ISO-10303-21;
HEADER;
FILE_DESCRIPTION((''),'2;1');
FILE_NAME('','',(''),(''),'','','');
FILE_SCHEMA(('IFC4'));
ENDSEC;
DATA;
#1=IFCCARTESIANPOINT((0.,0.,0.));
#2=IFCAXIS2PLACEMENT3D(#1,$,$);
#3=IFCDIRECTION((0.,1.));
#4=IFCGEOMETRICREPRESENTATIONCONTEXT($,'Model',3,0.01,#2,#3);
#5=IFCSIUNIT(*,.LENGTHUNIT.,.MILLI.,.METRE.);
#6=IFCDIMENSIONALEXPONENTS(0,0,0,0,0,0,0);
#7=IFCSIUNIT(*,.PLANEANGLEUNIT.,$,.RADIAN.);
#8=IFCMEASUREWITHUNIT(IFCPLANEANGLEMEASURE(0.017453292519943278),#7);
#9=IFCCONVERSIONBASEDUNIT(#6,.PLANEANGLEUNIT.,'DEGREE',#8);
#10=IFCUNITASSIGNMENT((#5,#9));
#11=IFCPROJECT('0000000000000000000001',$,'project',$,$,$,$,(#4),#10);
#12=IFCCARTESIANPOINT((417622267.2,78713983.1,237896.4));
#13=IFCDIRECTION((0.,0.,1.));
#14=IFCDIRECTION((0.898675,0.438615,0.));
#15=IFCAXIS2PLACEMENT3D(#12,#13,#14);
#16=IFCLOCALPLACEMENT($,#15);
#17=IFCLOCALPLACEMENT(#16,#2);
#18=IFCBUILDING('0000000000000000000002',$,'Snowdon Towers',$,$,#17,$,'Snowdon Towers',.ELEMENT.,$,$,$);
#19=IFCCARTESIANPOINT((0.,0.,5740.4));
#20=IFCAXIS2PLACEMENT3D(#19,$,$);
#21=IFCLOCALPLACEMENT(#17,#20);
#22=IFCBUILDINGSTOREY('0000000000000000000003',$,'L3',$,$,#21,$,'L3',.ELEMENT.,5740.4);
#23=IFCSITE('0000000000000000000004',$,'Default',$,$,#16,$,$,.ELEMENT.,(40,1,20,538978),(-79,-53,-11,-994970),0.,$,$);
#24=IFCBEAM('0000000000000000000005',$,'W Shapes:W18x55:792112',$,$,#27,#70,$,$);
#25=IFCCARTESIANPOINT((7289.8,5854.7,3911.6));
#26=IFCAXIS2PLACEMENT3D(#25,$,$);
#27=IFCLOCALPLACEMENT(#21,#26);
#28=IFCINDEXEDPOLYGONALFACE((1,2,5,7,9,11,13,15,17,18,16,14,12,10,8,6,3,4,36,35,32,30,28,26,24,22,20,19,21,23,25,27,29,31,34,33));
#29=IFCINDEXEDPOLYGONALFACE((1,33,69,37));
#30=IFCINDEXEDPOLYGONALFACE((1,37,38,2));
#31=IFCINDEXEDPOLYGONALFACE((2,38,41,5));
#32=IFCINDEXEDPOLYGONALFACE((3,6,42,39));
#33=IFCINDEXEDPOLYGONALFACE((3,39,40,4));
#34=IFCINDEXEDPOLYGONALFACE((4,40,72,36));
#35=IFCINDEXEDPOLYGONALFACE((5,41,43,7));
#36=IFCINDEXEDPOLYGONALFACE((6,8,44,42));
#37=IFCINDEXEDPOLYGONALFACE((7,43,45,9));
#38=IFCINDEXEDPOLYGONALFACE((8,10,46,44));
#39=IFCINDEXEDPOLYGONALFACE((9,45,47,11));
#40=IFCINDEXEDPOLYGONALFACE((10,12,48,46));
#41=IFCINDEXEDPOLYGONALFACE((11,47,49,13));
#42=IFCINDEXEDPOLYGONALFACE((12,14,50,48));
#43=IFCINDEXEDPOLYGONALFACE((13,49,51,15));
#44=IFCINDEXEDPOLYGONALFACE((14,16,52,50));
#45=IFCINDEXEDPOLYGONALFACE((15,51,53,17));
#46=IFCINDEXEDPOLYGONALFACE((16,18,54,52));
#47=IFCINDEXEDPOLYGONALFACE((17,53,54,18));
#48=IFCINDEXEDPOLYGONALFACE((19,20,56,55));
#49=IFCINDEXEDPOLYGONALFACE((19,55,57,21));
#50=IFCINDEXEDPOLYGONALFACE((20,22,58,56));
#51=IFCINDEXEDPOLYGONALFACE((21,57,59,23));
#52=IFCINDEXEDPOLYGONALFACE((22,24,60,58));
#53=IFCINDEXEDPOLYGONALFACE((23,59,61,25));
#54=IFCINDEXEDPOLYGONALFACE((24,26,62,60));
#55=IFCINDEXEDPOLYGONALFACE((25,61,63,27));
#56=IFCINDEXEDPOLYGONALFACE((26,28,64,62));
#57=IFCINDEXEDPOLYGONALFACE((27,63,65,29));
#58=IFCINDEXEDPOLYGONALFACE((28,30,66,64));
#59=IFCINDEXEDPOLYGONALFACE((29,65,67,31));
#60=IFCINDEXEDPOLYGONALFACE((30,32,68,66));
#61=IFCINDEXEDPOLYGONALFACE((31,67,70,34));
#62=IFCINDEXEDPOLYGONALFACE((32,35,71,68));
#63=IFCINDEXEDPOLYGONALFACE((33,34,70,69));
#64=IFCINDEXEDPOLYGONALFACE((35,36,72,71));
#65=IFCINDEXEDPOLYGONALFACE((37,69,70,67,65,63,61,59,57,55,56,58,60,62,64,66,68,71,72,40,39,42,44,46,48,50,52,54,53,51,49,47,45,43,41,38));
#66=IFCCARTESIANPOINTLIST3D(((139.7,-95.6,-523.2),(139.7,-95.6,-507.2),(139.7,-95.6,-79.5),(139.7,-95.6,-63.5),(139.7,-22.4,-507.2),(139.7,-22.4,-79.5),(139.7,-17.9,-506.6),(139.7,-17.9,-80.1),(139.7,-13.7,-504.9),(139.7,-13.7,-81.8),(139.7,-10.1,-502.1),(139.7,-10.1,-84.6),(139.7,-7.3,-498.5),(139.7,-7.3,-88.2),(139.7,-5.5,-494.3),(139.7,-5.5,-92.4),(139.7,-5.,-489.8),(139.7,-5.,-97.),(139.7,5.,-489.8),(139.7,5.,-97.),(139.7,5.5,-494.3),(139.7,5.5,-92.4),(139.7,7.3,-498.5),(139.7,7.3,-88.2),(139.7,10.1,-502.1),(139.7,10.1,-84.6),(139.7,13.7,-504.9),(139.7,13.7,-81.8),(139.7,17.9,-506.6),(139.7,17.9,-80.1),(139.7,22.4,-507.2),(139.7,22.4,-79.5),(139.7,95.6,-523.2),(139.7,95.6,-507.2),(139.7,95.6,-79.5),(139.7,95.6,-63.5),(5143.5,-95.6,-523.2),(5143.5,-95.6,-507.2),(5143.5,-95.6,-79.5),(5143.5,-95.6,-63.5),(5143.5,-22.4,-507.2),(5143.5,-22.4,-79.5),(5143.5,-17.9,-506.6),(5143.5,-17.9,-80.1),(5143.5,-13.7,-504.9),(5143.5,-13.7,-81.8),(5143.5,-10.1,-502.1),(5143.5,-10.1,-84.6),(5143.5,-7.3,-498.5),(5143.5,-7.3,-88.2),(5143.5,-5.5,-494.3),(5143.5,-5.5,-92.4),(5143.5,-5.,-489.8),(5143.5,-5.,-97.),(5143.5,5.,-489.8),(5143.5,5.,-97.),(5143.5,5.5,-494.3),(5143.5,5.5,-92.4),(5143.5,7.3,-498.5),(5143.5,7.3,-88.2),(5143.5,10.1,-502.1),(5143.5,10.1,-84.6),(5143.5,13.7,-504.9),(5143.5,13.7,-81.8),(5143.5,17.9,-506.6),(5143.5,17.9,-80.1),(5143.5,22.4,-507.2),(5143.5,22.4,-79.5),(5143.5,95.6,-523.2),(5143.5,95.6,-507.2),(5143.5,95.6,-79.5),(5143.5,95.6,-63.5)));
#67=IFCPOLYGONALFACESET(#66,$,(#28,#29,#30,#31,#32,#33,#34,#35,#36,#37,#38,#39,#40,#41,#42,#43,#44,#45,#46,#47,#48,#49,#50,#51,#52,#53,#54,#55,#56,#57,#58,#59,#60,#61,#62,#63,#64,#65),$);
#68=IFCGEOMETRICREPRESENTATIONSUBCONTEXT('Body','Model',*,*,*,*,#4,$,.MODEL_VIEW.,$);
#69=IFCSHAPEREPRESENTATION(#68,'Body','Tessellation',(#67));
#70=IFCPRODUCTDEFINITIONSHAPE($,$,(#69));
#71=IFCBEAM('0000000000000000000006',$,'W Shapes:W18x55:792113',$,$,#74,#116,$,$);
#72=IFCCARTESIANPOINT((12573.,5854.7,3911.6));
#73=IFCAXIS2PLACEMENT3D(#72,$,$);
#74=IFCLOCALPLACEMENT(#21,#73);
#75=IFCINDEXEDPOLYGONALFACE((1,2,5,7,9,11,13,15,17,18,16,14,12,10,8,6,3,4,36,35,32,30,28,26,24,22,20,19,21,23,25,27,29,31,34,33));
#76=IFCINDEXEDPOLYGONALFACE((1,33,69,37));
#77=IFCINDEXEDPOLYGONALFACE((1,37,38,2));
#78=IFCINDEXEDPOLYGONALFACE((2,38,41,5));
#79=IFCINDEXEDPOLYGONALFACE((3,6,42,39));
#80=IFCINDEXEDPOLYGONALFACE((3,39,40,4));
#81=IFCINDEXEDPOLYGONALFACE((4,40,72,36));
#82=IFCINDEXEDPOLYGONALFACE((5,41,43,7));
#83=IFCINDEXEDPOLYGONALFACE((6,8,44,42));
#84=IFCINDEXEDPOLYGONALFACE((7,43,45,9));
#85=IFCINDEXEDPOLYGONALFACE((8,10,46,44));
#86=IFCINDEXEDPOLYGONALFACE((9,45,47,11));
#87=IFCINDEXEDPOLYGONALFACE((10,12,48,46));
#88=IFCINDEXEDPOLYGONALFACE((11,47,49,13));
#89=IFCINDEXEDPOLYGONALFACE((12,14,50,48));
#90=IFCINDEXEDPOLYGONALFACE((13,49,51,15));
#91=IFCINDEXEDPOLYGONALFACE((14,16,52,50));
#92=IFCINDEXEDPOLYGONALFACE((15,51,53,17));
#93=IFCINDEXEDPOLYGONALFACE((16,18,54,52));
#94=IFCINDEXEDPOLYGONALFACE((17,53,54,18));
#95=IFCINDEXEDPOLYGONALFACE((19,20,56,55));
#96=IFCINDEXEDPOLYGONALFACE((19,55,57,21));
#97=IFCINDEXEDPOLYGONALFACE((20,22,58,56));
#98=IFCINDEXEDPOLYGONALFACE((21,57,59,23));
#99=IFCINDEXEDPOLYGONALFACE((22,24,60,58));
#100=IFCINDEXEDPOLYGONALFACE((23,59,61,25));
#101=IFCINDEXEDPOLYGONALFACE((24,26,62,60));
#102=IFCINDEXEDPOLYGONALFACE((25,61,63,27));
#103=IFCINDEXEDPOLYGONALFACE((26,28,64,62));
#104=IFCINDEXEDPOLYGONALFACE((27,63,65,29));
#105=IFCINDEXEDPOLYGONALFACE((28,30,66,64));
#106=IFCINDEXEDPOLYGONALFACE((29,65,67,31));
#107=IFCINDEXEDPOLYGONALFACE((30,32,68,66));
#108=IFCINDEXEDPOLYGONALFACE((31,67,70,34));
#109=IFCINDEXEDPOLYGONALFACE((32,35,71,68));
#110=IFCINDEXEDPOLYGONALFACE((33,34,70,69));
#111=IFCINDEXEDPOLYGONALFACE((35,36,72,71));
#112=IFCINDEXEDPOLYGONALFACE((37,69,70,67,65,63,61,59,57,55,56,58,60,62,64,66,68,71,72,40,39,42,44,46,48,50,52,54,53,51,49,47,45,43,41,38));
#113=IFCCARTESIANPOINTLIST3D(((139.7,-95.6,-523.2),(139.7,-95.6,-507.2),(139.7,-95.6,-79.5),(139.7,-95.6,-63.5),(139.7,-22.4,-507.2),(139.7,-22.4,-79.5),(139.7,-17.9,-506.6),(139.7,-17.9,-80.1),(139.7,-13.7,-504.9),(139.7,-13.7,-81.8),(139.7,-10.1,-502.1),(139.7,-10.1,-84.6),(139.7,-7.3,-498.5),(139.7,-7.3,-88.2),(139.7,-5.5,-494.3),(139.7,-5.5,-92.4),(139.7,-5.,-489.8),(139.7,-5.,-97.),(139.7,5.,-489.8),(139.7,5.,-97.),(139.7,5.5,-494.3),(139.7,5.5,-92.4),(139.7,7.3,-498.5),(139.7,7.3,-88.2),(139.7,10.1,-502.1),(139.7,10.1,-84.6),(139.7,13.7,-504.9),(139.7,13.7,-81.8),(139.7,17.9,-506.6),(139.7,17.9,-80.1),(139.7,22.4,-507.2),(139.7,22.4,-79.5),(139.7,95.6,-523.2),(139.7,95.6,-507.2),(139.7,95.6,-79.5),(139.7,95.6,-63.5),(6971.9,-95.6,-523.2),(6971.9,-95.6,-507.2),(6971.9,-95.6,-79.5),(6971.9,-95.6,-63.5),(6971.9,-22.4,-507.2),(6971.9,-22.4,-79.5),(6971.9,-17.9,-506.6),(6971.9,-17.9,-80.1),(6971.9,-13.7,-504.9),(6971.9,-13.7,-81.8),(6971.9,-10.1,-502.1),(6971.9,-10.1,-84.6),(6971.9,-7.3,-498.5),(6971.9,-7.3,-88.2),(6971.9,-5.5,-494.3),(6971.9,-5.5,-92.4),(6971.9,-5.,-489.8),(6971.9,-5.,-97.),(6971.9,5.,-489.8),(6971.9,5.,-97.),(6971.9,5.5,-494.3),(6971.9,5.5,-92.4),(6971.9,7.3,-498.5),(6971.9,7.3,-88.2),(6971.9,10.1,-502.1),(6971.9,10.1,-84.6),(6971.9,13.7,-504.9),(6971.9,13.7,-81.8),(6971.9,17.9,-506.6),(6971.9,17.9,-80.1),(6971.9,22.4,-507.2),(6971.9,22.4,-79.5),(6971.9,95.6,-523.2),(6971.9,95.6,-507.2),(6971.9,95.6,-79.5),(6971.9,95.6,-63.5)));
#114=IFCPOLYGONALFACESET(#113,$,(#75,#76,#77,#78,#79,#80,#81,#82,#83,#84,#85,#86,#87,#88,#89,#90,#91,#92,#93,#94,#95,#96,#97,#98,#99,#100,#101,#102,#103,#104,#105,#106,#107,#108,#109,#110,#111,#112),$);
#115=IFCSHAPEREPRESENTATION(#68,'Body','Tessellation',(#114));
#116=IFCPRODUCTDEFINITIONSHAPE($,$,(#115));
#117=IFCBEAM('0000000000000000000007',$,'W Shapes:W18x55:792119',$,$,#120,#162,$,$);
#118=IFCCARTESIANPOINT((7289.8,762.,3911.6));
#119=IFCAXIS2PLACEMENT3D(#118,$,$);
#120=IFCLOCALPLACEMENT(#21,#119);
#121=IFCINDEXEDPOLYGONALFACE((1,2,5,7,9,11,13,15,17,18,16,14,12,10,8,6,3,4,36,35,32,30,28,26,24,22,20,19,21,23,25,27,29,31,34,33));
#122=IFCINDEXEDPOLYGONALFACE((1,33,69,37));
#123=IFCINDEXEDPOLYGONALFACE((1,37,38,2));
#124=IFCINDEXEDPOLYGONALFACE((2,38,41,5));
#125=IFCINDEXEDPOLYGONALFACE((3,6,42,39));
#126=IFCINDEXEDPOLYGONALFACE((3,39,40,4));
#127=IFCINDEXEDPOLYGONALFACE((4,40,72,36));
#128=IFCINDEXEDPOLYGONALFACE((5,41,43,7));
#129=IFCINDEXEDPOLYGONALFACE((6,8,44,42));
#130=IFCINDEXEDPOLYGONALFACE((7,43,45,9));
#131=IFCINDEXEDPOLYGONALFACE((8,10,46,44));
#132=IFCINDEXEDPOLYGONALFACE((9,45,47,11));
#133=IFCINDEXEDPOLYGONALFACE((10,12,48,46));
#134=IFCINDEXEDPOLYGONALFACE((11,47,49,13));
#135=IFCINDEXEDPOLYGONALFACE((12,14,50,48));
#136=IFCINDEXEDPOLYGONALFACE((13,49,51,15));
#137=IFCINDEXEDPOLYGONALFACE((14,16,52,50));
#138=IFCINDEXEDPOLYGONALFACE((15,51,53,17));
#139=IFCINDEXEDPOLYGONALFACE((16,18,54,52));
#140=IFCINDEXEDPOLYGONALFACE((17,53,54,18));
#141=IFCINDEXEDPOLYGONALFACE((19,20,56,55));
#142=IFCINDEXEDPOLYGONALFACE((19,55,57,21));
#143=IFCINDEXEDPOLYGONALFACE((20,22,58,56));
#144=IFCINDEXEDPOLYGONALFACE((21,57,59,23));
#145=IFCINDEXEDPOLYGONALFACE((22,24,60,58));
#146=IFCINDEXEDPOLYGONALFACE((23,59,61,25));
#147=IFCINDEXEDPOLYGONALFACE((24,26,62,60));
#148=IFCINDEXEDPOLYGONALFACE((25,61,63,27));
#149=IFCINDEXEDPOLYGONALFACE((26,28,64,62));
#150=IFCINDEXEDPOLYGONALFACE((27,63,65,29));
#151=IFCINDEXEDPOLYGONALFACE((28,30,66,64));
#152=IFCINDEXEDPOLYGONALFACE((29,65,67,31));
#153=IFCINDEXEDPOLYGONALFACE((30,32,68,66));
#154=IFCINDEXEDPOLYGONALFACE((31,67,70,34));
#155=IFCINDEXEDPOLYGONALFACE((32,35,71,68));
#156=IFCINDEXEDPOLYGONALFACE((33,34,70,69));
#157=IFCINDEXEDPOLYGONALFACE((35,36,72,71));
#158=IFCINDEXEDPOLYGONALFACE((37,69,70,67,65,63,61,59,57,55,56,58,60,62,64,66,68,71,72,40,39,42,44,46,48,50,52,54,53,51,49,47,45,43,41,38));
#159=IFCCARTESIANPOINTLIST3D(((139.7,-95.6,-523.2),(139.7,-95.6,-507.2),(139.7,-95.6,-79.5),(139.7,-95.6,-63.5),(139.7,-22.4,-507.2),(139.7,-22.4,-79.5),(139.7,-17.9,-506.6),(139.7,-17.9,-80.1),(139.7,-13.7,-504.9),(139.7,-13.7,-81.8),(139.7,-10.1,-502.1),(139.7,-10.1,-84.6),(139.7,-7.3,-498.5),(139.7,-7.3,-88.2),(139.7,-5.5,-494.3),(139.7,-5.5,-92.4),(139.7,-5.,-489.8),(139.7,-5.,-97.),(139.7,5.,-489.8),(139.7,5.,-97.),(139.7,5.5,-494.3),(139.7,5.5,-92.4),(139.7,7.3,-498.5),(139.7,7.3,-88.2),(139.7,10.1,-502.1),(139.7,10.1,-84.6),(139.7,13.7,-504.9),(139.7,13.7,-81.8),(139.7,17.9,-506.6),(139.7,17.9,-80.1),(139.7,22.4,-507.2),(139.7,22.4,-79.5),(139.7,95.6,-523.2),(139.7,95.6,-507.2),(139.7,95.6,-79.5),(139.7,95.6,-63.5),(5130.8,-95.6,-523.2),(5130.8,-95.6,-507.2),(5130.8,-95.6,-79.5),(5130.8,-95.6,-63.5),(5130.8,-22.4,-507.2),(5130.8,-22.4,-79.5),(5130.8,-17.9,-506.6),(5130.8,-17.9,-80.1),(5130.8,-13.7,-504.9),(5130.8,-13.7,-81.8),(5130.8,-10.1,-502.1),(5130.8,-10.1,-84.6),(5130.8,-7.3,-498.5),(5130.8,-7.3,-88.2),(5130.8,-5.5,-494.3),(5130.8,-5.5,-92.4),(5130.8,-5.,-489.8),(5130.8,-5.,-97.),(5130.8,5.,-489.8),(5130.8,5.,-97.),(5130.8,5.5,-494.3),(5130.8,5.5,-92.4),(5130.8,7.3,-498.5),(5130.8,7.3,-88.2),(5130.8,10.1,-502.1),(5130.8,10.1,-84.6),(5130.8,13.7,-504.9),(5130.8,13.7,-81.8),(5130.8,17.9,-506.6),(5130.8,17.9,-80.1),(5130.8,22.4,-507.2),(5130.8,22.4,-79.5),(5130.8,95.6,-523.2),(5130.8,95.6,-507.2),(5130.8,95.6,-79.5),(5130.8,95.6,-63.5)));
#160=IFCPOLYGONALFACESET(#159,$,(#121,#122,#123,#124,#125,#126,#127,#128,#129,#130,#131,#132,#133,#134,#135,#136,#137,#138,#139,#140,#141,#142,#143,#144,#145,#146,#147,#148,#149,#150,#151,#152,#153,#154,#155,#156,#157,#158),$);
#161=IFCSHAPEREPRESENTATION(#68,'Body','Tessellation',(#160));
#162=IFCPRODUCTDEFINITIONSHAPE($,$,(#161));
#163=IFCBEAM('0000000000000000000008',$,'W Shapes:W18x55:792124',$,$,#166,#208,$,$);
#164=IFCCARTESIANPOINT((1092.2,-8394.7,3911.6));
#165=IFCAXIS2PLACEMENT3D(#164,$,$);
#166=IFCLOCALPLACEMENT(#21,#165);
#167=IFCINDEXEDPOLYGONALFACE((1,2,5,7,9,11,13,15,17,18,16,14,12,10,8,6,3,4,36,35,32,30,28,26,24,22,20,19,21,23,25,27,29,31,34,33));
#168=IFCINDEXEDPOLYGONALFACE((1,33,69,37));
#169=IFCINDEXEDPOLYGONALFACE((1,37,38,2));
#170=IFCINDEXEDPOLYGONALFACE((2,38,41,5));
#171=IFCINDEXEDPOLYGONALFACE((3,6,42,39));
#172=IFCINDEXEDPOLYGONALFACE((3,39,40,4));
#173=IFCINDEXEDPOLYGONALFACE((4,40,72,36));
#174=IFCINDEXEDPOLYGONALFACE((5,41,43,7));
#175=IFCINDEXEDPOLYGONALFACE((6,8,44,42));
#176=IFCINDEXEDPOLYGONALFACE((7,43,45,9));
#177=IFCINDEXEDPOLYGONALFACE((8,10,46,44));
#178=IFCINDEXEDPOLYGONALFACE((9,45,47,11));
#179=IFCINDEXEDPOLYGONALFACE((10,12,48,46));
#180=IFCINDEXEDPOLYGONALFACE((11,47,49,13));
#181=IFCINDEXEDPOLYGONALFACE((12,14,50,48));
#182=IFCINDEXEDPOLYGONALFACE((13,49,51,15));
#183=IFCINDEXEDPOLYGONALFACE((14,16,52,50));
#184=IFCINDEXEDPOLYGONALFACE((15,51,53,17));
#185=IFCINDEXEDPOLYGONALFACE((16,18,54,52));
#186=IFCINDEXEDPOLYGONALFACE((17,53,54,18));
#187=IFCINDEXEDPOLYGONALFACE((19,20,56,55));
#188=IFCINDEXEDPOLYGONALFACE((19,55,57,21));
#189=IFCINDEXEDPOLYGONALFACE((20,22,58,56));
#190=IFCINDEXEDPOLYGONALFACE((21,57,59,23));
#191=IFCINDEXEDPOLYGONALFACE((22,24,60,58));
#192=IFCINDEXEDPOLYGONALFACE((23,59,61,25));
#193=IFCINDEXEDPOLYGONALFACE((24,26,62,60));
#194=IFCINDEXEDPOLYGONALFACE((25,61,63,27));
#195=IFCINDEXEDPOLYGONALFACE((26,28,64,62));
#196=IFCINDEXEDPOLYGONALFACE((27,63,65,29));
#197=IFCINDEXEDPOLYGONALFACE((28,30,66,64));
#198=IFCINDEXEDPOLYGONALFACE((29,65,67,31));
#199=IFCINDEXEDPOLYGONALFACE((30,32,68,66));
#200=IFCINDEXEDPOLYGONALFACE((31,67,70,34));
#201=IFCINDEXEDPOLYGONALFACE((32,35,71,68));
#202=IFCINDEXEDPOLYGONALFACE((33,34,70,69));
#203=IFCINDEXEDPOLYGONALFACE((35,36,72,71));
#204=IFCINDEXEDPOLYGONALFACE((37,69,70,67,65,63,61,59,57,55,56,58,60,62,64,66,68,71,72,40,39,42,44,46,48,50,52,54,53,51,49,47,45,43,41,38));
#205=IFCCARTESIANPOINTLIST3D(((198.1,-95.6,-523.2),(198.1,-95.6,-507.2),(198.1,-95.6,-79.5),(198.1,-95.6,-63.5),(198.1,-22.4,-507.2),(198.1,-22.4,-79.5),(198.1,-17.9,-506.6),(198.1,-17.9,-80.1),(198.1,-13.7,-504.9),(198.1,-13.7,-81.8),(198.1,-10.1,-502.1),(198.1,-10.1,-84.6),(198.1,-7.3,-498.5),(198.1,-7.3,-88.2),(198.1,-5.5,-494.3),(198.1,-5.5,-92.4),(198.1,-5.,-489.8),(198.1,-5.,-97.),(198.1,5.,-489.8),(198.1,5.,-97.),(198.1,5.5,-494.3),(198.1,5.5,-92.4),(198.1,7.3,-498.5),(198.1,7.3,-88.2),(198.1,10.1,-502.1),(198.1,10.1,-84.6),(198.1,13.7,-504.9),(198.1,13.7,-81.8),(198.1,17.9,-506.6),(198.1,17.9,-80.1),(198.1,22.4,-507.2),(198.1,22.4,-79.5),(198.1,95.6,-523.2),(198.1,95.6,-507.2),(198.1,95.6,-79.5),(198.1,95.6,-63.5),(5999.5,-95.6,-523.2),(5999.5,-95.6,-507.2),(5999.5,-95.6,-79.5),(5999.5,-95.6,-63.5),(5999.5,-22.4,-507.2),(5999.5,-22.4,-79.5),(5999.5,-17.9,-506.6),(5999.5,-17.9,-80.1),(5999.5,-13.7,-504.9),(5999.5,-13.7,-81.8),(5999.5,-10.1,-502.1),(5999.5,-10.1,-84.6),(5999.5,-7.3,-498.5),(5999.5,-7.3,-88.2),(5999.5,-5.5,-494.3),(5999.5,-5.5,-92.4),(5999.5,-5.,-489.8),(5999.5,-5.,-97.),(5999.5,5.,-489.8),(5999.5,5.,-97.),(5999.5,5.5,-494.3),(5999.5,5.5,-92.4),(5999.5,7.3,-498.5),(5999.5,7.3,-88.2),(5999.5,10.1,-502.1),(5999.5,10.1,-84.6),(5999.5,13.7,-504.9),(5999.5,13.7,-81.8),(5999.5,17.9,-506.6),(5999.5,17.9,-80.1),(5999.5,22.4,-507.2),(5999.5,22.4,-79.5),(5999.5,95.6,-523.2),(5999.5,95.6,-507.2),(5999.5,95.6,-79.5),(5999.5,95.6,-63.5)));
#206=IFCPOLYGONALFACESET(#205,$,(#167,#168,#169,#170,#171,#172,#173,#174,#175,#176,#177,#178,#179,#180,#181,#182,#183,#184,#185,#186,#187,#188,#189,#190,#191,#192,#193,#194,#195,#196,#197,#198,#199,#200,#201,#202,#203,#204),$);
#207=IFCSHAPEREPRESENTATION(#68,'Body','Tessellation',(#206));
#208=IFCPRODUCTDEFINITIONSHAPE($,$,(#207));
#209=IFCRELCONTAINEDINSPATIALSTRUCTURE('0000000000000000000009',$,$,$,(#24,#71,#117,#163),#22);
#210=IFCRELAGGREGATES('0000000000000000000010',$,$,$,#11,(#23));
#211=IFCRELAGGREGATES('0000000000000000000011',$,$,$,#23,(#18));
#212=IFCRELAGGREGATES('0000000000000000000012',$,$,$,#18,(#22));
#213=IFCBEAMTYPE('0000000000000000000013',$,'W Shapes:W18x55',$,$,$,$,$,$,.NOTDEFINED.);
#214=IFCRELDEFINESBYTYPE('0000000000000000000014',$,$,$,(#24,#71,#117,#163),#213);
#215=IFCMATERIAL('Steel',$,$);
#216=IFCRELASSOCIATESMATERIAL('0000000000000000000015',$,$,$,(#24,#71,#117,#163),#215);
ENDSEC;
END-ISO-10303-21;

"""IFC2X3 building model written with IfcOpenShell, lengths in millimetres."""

from ifc_helpers import new_model, entity, si_unit, converted_unit, direction, frame, frame_2d, origin, place, context, subcontext, project, spatial, i_section, extrude, material, type_object, element, save


model = new_model("IFC2X3")

# Units and contexts
model_context = context("Model", 3, precision=0.01, world=origin(), true_north=direction((0.0, 1.0)))
body_context = subcontext(model_context, "Body", "Model", "MODEL_VIEW")
ifc_project = project(units=[si_unit("LENGTHUNIT", "METRE", prefix="MILLI"), converted_unit("PLANEANGLEUNIT", "DEGREE", entity("IfcPlaneAngleMeasure", 0.017453292519943278), si_unit("PLANEANGLEUNIT", "RADIAN"), dimensions=[0, 0, 0, 0, 0, 0, 0])], contexts=[model_context])

# Site, building, storey
site_placement = place(None, frame((417622267.2, 78713983.1, 237896.4), z_axis=(0.0, 0.0, 1.0), x_axis=(0.898675, 0.438615, 0.0)))
site = spatial("IfcSite", under=ifc_project, at=site_placement, Name="Default", CompositionType="ELEMENT", RefLatitude=(40, 1, 20, 538978), RefLongitude=(-79, -53, -11, -994970), RefElevation=0.0)
building_placement = place(site_placement, origin())
building = spatial("IfcBuilding", under=site, at=building_placement, Name="Snowdon Towers", LongName="Snowdon Towers", CompositionType="ELEMENT")
storey_placement = place(building_placement, frame((0.0, 0.0, 5740.4)))
storey = spatial("IfcBuildingStorey", under=building, at=storey_placement, Name="L3", LongName="L3", CompositionType="ELEMENT", Elevation=5740.4)

# Shared definitions
ifc_material_1 = material(Name="Steel")

# Beams
beam_type_1 = type_object("IfcBeamType", Name="W Shapes:W18x55", PredefinedType="NOTDEFINED")
beam_1_placement = place(storey_placement, frame((7289.8, 5854.7, 3911.6)))
element("IfcBeam", 1, at=beam_1_placement, inside=storey, type_object=beam_type_1, material=ifc_material_1, Name="W Shapes:W18x55:792112", context=body_context, shape_type="SweptSolid", body=[
    extrude(i_section(OverallWidth=191.3, OverallDepth=459.7, WebThickness=9.9, FlangeThickness=16.0, FilletRadius=17.5, at=frame_2d((0.0, 0.0), x_axis=(0.0, 1.0))), frame((139.7, 0.0, -293.4), z_axis=(1.0, 0.0, 0.0), x_axis=(0.0, 0.0, -1.0)), (0.0, 0.0, 1.0), 5003.8),
])
beam_2_placement = place(storey_placement, frame((12573.0, 5854.7, 3911.6)))
element("IfcBeam", 2, at=beam_2_placement, inside=storey, type_object=beam_type_1, material=ifc_material_1, Name="W Shapes:W18x55:792113", context=body_context, shape_type="SweptSolid", body=[
    extrude(i_section(OverallWidth=191.3, OverallDepth=459.7, WebThickness=9.9, FlangeThickness=16.0, FilletRadius=17.5, at=frame_2d((0.0, 0.0), x_axis=(0.0, 1.0))), frame((139.7, 0.0, -293.4), z_axis=(1.0, 0.0, 0.0), x_axis=(0.0, 0.0, -1.0)), (0.0, 0.0, 1.0), 6832.2),
])
beam_3_placement = place(storey_placement, frame((7289.8, 762.0, 3911.6)))
element("IfcBeam", 3, at=beam_3_placement, inside=storey, type_object=beam_type_1, material=ifc_material_1, Name="W Shapes:W18x55:792119", context=body_context, shape_type="SweptSolid", body=[
    extrude(i_section(OverallWidth=191.3, OverallDepth=459.7, WebThickness=9.9, FlangeThickness=16.0, FilletRadius=17.5, at=frame_2d((0.0, 0.0), x_axis=(0.0, 1.0))), frame((139.7, 0.0, -293.4), z_axis=(1.0, 0.0, 0.0), x_axis=(0.0, 0.0, -1.0)), (0.0, 0.0, 1.0), 4991.1),
])
beam_4_placement = place(storey_placement, frame((1092.2, -8394.7, 3911.6)))
element("IfcBeam", 4, at=beam_4_placement, inside=storey, type_object=beam_type_1, material=ifc_material_1, Name="W Shapes:W18x55:792124", context=body_context, shape_type="SweptSolid", body=[
    extrude(i_section(OverallWidth=191.3, OverallDepth=459.7, WebThickness=9.9, FlangeThickness=16.0, FilletRadius=17.5, at=frame_2d((0.0, 0.0), x_axis=(0.0, 1.0))), frame((198.1, 0.0, -293.4), z_axis=(1.0, 0.0, 0.0), x_axis=(0.0, 0.0, -1.0)), (0.0, 0.0, 1.0), 5801.4),
])

save(model, "model.ifc")
